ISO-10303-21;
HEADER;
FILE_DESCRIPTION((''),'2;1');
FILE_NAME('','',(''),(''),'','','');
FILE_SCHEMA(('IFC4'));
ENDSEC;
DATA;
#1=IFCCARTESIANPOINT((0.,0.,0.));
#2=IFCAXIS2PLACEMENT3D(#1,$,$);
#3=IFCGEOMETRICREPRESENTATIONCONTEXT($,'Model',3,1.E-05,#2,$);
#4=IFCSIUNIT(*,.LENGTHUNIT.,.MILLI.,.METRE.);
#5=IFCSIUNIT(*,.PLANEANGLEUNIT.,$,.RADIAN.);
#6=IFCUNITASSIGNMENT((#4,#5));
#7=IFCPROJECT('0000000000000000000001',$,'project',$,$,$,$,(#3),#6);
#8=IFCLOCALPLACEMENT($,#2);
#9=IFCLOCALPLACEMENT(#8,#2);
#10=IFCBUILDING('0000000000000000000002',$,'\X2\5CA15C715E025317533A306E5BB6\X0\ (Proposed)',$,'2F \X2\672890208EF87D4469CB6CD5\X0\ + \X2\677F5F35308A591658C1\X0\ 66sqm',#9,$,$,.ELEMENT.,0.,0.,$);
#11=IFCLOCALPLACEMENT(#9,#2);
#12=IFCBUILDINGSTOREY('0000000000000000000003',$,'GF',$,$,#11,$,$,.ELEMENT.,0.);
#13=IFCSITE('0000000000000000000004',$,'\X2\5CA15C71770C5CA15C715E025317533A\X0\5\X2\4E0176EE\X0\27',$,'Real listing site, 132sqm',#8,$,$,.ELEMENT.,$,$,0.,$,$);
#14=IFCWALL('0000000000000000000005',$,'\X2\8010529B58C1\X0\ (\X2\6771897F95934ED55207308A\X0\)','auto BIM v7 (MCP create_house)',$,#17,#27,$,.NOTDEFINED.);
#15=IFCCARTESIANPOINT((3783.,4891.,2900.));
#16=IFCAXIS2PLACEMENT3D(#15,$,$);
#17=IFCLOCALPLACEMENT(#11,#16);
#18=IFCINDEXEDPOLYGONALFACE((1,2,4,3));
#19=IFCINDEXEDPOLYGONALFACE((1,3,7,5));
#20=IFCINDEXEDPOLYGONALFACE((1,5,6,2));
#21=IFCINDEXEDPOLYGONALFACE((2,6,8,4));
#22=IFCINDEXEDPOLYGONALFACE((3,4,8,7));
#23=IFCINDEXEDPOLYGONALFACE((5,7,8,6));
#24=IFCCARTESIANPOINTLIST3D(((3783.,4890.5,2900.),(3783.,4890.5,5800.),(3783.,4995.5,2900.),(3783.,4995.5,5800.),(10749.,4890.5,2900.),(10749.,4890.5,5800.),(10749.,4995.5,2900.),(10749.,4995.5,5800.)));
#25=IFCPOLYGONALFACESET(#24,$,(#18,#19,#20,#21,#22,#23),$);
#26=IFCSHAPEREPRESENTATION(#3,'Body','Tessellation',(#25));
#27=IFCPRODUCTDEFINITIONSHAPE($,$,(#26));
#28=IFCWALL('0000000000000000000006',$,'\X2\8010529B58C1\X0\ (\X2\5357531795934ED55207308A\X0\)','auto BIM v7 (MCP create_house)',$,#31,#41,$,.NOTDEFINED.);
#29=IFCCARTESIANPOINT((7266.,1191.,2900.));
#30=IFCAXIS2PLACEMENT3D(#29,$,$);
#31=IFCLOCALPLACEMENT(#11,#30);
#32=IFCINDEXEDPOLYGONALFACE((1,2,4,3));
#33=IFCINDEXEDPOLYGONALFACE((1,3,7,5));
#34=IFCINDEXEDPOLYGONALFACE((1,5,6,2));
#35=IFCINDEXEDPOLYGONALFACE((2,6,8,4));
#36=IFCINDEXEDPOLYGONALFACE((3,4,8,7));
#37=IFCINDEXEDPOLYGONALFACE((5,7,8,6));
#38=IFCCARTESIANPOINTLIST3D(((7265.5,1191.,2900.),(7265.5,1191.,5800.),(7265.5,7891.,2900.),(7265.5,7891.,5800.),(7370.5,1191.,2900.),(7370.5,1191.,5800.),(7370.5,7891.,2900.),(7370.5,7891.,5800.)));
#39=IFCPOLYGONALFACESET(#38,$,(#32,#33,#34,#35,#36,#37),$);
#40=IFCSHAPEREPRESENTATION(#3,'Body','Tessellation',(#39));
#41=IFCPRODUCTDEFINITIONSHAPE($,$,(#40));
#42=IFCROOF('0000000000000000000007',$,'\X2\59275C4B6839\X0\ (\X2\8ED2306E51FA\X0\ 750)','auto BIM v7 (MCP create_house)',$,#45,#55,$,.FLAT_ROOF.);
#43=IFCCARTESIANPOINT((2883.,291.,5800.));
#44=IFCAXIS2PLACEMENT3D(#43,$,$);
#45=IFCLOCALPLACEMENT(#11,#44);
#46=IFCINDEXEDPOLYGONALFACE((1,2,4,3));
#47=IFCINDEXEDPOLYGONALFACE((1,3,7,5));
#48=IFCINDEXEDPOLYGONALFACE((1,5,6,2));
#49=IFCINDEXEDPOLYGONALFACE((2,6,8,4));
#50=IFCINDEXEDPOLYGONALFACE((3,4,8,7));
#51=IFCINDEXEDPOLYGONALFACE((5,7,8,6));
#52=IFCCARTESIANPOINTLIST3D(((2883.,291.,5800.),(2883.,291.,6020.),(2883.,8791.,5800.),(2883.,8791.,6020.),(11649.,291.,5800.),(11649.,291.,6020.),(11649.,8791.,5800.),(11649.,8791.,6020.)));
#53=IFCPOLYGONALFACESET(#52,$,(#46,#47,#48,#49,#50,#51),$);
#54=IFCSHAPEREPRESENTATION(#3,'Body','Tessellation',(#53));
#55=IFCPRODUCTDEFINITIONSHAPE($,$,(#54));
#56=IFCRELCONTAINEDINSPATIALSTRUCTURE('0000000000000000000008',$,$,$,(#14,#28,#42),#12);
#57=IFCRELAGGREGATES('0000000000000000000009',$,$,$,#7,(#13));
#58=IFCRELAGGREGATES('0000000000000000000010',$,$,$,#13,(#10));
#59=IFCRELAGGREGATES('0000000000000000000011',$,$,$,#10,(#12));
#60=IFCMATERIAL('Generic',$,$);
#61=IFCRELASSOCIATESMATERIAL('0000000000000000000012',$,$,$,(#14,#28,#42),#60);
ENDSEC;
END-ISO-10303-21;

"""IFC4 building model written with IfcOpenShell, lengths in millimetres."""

from ifc_helpers import new_model, si_unit, frame, frame_2d, origin, place, context, project, spatial, rectangle, extrude, material, element, save


model = new_model("IFC4")

# Units and contexts
model_context = context("Model", 3, precision=1e-05, world=origin())
ifc_project = project(units=[si_unit("LENGTHUNIT", "METRE", prefix="MILLI"), si_unit("PLANEANGLEUNIT", "RADIAN")], contexts=[model_context])

# Site, building, storey
site_placement = place(None, origin())
site = spatial("IfcSite", under=ifc_project, at=site_placement, Name="岡山県岡山市北区5丁目27", ObjectType="Real listing site, 132sqm", CompositionType="ELEMENT", RefElevation=0.0)
building_placement = place(site_placement, origin())
building = spatial("IfcBuilding", under=site, at=building_placement, Name="岡山市北区の家 (Proposed)", ObjectType="2F 木造軸組構法 + 板張り外壁 66sqm", CompositionType="ELEMENT", ElevationOfRefHeight=0.0, ElevationOfTerrain=0.0)
storey_placement = place(building_placement, origin())
storey = spatial("IfcBuildingStorey", under=building, at=storey_placement, Name="GF", CompositionType="ELEMENT", Elevation=0.0)

# Shared definitions
ifc_material = material(Name="Generic")

# Walls
wall_1_placement = place(storey_placement, frame((3783.0, 4891.0, 2900.0)))
element("IfcWall", 1, at=wall_1_placement, inside=storey, material=ifc_material, Name="耐力壁 (東西間仕切り)", Description="auto BIM v7 (MCP create_house)", PredefinedType="NOTDEFINED", context=model_context, shape_type="SweptSolid", body=[
    extrude(rectangle(XDim=6966.0, YDim=105.0, at=frame_2d((3483.0, 52.0))), frame((3783.0, 4891.0, 2900.0)), (0.0, 0.0, 1.0), 2900.0),
])
wall_2_placement = place(storey_placement, frame((7266.0, 1191.0, 2900.0)))
element("IfcWall", 2, at=wall_2_placement, inside=storey, material=ifc_material, Name="耐力壁 (南北間仕切り)", Description="auto BIM v7 (MCP create_house)", PredefinedType="NOTDEFINED", context=model_context, shape_type="SweptSolid", body=[
    extrude(rectangle(XDim=105.0, YDim=6700.0, at=frame_2d((52.0, 3350.0))), frame((7266.0, 1191.0, 2900.0)), (0.0, 0.0, 1.0), 2900.0),
])

# Roof
roof_placement = place(storey_placement, frame((2883.0, 291.0, 5800.0)))
element("IfcRoof", 3, at=roof_placement, inside=storey, material=ifc_material, Name="大屋根 (軒の出 750)", Description="auto BIM v7 (MCP create_house)", PredefinedType="FLAT_ROOF", context=model_context, shape_type="SweptSolid", body=[
    extrude(rectangle(XDim=8766.0, YDim=8500.0, at=frame_2d((4383.0, 4250.0))), frame((2883.0, 291.0, 5800.0)), (0.0, 0.0, 1.0), 220.0),
])

save(model, "model.ifc")
